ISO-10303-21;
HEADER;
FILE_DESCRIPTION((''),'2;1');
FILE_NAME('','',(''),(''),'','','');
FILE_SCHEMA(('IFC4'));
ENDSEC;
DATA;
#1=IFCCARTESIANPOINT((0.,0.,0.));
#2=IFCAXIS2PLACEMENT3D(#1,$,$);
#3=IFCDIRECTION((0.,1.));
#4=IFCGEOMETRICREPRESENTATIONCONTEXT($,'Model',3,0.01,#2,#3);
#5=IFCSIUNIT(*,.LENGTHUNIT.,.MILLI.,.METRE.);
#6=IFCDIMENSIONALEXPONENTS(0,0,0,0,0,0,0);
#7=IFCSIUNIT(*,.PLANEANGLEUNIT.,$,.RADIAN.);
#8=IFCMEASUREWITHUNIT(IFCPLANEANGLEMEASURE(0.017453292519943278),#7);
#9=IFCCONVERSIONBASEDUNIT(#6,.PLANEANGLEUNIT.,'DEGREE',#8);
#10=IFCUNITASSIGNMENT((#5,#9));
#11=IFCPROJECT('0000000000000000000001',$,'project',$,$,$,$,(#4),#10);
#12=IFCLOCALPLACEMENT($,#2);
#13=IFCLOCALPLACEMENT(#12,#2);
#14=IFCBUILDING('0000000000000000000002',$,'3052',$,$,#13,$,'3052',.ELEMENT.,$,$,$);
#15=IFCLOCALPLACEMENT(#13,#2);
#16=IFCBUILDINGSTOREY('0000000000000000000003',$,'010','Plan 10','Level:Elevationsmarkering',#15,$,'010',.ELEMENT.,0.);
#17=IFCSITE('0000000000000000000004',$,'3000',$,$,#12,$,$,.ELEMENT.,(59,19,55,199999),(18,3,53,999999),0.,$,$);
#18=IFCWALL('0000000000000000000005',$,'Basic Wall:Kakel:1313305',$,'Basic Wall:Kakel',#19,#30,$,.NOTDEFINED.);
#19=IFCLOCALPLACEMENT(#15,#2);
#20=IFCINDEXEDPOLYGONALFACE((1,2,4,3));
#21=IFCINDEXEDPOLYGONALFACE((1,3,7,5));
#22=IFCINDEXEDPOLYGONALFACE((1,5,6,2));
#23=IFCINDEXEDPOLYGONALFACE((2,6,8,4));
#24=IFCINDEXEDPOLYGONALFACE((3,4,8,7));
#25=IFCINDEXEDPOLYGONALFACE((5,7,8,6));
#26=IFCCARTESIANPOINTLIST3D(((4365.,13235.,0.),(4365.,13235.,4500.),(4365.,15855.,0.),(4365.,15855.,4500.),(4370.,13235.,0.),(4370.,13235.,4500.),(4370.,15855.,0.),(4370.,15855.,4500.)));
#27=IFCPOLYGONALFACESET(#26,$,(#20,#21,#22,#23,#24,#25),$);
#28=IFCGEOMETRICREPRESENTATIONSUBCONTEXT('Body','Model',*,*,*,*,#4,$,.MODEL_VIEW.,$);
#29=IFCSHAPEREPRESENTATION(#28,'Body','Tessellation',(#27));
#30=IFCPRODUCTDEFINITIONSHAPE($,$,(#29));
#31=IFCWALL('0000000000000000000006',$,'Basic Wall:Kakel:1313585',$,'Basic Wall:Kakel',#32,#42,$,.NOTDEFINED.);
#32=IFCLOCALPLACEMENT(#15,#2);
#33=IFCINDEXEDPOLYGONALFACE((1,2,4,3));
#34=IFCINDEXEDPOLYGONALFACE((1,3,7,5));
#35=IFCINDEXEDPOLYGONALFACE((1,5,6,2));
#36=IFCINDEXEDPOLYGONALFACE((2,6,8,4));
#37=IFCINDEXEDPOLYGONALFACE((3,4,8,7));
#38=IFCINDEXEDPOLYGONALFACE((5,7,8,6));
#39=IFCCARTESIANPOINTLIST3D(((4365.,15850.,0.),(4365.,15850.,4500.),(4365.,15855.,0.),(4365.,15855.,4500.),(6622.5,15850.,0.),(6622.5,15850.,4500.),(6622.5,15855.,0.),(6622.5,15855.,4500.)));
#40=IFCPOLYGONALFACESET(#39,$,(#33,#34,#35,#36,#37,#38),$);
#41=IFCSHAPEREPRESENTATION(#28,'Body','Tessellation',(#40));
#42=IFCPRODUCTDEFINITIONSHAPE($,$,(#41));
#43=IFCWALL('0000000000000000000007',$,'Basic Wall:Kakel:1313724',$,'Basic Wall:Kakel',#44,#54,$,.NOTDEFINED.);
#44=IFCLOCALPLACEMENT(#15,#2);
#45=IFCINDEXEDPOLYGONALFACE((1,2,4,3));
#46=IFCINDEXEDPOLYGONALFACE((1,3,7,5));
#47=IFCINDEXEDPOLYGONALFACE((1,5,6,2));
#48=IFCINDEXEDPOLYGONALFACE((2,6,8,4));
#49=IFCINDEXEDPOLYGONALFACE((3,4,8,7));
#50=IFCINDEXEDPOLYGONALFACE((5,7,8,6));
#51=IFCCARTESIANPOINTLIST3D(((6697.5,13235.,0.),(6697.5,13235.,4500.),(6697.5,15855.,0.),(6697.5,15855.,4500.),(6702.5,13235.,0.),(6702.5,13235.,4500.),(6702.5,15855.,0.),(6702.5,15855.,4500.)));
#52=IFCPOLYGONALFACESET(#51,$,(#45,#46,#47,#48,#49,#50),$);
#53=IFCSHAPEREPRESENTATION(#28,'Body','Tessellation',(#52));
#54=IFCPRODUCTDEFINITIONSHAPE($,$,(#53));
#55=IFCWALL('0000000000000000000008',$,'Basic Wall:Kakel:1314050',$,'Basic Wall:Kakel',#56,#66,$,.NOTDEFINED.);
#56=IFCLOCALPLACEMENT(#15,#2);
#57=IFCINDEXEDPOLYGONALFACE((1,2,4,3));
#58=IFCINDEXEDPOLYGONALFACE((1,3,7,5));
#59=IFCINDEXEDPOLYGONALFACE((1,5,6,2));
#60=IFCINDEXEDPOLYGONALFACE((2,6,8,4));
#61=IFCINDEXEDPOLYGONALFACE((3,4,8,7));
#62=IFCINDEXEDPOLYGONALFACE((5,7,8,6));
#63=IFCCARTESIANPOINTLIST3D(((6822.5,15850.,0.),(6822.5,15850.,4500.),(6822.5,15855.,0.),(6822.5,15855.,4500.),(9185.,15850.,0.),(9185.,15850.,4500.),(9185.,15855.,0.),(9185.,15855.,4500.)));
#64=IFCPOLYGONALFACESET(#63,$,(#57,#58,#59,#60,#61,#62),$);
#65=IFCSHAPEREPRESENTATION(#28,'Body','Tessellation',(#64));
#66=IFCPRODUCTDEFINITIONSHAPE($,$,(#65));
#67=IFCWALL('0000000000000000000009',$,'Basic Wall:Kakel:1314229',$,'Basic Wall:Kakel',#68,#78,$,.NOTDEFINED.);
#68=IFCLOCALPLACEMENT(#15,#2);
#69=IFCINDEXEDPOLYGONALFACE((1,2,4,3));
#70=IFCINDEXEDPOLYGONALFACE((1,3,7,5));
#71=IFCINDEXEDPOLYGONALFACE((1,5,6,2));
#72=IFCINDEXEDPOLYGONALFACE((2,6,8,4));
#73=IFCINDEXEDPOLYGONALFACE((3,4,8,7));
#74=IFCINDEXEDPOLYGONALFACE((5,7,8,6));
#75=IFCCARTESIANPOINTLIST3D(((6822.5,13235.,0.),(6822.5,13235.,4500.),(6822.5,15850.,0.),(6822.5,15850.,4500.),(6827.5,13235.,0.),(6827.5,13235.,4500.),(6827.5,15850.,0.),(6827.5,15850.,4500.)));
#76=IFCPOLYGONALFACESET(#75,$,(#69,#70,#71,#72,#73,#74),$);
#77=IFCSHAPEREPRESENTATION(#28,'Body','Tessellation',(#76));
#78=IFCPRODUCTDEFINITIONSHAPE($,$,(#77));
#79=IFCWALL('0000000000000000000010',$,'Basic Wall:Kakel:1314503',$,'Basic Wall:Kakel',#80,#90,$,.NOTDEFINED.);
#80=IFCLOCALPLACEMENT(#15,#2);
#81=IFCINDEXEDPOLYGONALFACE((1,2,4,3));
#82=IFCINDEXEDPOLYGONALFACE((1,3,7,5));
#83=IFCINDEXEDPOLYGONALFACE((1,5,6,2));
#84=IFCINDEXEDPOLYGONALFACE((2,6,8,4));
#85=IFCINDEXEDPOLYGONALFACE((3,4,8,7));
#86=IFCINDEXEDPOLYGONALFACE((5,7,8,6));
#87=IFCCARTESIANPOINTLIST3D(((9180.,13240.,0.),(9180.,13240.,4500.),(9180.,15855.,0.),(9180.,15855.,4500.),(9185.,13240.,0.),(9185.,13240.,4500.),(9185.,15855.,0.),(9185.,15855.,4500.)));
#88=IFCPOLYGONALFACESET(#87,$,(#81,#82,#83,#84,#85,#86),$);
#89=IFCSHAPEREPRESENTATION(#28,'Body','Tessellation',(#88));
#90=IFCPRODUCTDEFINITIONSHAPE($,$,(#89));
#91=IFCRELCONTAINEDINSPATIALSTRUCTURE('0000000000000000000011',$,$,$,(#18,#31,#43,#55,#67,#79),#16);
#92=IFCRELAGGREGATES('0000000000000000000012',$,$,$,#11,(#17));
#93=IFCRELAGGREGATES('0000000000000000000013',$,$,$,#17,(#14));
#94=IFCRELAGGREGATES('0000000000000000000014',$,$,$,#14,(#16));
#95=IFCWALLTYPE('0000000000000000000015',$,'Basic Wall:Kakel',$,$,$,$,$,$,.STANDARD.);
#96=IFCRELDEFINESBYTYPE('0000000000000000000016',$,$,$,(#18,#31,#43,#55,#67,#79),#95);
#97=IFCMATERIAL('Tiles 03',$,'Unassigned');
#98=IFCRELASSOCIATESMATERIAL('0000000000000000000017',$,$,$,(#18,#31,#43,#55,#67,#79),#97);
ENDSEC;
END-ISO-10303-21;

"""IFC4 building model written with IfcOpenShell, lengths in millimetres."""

from ifc_helpers import new_model, entity, si_unit, converted_unit, direction, frame, origin, place, context, subcontext, project, spatial, indexed_curve, outline, extrude, material, type_object, element, save


model = new_model("IFC4")

# Units and contexts
model_context = context("Model", 3, precision=0.01, world=origin(), true_north=direction((0.0, 1.0)))
body_context = subcontext(model_context, "Body", "Model", "MODEL_VIEW")
ifc_project = project(units=[si_unit("LENGTHUNIT", "METRE", prefix="MILLI"), converted_unit("PLANEANGLEUNIT", "DEGREE", entity("IfcPlaneAngleMeasure", 0.017453292519943278), si_unit("PLANEANGLEUNIT", "RADIAN"), dimensions=[0, 0, 0, 0, 0, 0, 0])], contexts=[model_context])

# Site, building, storey
site_placement = place(None, origin())
site = spatial("IfcSite", under=ifc_project, at=site_placement, Name="3000", CompositionType="ELEMENT", RefLatitude=(59, 19, 55, 199999), RefLongitude=(18, 3, 53, 999999), RefElevation=0.0)
building_placement = place(site_placement, origin())
building = spatial("IfcBuilding", under=site, at=building_placement, Name="3052", LongName="3052", CompositionType="ELEMENT")
storey_placement = place(building_placement, origin())
storey = spatial("IfcBuildingStorey", under=building, at=storey_placement, Name="010", Description="Plan 10", ObjectType="Level:Elevationsmarkering", LongName="010", CompositionType="ELEMENT", Elevation=0.0)

# Walls
ifc_material_1 = material(Name="Tiles 03", Category="Unassigned")
wall_type_1 = type_object("IfcWallType", Name="Basic Wall:Kakel", PredefinedType="STANDARD")
wall_1_placement = place(storey_placement, frame((4367.5, 15855.0, 0.0), z_axis=(0.0, 0.0, 1.0), x_axis=(0.0, -1.0, 0.0)))
element("IfcWall", 1, at=wall_1_placement, inside=storey, type_object=wall_type_1, material=ifc_material_1, Name="Basic Wall:Kakel:1313305", ObjectType="Basic Wall:Kakel", PredefinedType="NOTDEFINED", context=body_context, shape_type="SweptSolid", body=[
    extrude(outline(indexed_curve([(2620.0, 2.5), (0.0, 2.5), (0.0, -2.5), (2620.0, -2.5), (2620.0, 2.5)], self_intersect=False)), origin(), (0.0, 0.0, 1.0), 4500.0),
])
wall_2_placement = place(storey_placement, frame((6622.5, 15852.5, 0.0), z_axis=(0.0, 0.0, 1.0), x_axis=(-1.0, 0.0, 0.0)))
element("IfcWall", 2, at=wall_2_placement, inside=storey, type_object=wall_type_1, material=ifc_material_1, Name="Basic Wall:Kakel:1313585", ObjectType="Basic Wall:Kakel", PredefinedType="NOTDEFINED", context=body_context, shape_type="SweptSolid", body=[
    extrude(outline(indexed_curve([(2257.5, 2.5), (0.0, 2.5), (0.0, -2.5), (2257.5, -2.5), (2257.5, 2.5)], self_intersect=False)), origin(), (0.0, 0.0, 1.0), 4500.0),
])
wall_3_placement = place(storey_placement, frame((6700.0, 13235.0, 0.0), z_axis=(0.0, 0.0, 1.0), x_axis=(0.0, 1.0, 0.0)))
element("IfcWall", 3, at=wall_3_placement, inside=storey, type_object=wall_type_1, material=ifc_material_1, Name="Basic Wall:Kakel:1313724", ObjectType="Basic Wall:Kakel", PredefinedType="NOTDEFINED", context=body_context, shape_type="SweptSolid", body=[
    extrude(outline(indexed_curve([(2620.0, 2.5), (0.0, 2.5), (0.0, -2.5), (2620.0, -2.5), (2620.0, 2.5)], self_intersect=False)), origin(), (0.0, 0.0, 1.0), 4500.0),
])
wall_4_placement = place(storey_placement, frame((9185.0, 15852.5, 0.0), z_axis=(0.0, 0.0, 1.0), x_axis=(-1.0, 0.0, 0.0)))
element("IfcWall", 4, at=wall_4_placement, inside=storey, type_object=wall_type_1, material=ifc_material_1, Name="Basic Wall:Kakel:1314050", ObjectType="Basic Wall:Kakel", PredefinedType="NOTDEFINED", context=body_context, shape_type="SweptSolid", body=[
    extrude(outline(indexed_curve([(2362.5, 2.5), (0.0, 2.5), (0.0, -2.5), (2362.5, -2.5), (2362.5, 2.5)], self_intersect=False)), origin(), (0.0, 0.0, 1.0), 4500.0),
])
for number, where, z_axis, x_axis, name in (
    (5, (6825.0, 15850.0, 0.0), (0.0, 0.0, 1.0), (0.0, -1.0, 0.0), "Basic Wall:Kakel:1314229"),
    (6, (9182.5, 13240.0, 0.0), (0.0, 0.0, 1.0), (0.0, 1.0, 0.0), "Basic Wall:Kakel:1314503"),
):
    element("IfcWall", number, at=place(storey_placement, frame(where, z_axis=z_axis, x_axis=x_axis)), inside=storey, type_object=wall_type_1, material=ifc_material_1, Name=name, ObjectType="Basic Wall:Kakel", PredefinedType="NOTDEFINED", context=body_context, shape_type="SweptSolid", body=[
        extrude(outline(indexed_curve([(2615.0, 2.5), (0.0, 2.5), (0.0, -2.5), (2615.0, -2.5), (2615.0, 2.5)], self_intersect=False)), origin(), (0.0, 0.0, 1.0), 4500.0),
    ])

save(model, "model.ifc")
